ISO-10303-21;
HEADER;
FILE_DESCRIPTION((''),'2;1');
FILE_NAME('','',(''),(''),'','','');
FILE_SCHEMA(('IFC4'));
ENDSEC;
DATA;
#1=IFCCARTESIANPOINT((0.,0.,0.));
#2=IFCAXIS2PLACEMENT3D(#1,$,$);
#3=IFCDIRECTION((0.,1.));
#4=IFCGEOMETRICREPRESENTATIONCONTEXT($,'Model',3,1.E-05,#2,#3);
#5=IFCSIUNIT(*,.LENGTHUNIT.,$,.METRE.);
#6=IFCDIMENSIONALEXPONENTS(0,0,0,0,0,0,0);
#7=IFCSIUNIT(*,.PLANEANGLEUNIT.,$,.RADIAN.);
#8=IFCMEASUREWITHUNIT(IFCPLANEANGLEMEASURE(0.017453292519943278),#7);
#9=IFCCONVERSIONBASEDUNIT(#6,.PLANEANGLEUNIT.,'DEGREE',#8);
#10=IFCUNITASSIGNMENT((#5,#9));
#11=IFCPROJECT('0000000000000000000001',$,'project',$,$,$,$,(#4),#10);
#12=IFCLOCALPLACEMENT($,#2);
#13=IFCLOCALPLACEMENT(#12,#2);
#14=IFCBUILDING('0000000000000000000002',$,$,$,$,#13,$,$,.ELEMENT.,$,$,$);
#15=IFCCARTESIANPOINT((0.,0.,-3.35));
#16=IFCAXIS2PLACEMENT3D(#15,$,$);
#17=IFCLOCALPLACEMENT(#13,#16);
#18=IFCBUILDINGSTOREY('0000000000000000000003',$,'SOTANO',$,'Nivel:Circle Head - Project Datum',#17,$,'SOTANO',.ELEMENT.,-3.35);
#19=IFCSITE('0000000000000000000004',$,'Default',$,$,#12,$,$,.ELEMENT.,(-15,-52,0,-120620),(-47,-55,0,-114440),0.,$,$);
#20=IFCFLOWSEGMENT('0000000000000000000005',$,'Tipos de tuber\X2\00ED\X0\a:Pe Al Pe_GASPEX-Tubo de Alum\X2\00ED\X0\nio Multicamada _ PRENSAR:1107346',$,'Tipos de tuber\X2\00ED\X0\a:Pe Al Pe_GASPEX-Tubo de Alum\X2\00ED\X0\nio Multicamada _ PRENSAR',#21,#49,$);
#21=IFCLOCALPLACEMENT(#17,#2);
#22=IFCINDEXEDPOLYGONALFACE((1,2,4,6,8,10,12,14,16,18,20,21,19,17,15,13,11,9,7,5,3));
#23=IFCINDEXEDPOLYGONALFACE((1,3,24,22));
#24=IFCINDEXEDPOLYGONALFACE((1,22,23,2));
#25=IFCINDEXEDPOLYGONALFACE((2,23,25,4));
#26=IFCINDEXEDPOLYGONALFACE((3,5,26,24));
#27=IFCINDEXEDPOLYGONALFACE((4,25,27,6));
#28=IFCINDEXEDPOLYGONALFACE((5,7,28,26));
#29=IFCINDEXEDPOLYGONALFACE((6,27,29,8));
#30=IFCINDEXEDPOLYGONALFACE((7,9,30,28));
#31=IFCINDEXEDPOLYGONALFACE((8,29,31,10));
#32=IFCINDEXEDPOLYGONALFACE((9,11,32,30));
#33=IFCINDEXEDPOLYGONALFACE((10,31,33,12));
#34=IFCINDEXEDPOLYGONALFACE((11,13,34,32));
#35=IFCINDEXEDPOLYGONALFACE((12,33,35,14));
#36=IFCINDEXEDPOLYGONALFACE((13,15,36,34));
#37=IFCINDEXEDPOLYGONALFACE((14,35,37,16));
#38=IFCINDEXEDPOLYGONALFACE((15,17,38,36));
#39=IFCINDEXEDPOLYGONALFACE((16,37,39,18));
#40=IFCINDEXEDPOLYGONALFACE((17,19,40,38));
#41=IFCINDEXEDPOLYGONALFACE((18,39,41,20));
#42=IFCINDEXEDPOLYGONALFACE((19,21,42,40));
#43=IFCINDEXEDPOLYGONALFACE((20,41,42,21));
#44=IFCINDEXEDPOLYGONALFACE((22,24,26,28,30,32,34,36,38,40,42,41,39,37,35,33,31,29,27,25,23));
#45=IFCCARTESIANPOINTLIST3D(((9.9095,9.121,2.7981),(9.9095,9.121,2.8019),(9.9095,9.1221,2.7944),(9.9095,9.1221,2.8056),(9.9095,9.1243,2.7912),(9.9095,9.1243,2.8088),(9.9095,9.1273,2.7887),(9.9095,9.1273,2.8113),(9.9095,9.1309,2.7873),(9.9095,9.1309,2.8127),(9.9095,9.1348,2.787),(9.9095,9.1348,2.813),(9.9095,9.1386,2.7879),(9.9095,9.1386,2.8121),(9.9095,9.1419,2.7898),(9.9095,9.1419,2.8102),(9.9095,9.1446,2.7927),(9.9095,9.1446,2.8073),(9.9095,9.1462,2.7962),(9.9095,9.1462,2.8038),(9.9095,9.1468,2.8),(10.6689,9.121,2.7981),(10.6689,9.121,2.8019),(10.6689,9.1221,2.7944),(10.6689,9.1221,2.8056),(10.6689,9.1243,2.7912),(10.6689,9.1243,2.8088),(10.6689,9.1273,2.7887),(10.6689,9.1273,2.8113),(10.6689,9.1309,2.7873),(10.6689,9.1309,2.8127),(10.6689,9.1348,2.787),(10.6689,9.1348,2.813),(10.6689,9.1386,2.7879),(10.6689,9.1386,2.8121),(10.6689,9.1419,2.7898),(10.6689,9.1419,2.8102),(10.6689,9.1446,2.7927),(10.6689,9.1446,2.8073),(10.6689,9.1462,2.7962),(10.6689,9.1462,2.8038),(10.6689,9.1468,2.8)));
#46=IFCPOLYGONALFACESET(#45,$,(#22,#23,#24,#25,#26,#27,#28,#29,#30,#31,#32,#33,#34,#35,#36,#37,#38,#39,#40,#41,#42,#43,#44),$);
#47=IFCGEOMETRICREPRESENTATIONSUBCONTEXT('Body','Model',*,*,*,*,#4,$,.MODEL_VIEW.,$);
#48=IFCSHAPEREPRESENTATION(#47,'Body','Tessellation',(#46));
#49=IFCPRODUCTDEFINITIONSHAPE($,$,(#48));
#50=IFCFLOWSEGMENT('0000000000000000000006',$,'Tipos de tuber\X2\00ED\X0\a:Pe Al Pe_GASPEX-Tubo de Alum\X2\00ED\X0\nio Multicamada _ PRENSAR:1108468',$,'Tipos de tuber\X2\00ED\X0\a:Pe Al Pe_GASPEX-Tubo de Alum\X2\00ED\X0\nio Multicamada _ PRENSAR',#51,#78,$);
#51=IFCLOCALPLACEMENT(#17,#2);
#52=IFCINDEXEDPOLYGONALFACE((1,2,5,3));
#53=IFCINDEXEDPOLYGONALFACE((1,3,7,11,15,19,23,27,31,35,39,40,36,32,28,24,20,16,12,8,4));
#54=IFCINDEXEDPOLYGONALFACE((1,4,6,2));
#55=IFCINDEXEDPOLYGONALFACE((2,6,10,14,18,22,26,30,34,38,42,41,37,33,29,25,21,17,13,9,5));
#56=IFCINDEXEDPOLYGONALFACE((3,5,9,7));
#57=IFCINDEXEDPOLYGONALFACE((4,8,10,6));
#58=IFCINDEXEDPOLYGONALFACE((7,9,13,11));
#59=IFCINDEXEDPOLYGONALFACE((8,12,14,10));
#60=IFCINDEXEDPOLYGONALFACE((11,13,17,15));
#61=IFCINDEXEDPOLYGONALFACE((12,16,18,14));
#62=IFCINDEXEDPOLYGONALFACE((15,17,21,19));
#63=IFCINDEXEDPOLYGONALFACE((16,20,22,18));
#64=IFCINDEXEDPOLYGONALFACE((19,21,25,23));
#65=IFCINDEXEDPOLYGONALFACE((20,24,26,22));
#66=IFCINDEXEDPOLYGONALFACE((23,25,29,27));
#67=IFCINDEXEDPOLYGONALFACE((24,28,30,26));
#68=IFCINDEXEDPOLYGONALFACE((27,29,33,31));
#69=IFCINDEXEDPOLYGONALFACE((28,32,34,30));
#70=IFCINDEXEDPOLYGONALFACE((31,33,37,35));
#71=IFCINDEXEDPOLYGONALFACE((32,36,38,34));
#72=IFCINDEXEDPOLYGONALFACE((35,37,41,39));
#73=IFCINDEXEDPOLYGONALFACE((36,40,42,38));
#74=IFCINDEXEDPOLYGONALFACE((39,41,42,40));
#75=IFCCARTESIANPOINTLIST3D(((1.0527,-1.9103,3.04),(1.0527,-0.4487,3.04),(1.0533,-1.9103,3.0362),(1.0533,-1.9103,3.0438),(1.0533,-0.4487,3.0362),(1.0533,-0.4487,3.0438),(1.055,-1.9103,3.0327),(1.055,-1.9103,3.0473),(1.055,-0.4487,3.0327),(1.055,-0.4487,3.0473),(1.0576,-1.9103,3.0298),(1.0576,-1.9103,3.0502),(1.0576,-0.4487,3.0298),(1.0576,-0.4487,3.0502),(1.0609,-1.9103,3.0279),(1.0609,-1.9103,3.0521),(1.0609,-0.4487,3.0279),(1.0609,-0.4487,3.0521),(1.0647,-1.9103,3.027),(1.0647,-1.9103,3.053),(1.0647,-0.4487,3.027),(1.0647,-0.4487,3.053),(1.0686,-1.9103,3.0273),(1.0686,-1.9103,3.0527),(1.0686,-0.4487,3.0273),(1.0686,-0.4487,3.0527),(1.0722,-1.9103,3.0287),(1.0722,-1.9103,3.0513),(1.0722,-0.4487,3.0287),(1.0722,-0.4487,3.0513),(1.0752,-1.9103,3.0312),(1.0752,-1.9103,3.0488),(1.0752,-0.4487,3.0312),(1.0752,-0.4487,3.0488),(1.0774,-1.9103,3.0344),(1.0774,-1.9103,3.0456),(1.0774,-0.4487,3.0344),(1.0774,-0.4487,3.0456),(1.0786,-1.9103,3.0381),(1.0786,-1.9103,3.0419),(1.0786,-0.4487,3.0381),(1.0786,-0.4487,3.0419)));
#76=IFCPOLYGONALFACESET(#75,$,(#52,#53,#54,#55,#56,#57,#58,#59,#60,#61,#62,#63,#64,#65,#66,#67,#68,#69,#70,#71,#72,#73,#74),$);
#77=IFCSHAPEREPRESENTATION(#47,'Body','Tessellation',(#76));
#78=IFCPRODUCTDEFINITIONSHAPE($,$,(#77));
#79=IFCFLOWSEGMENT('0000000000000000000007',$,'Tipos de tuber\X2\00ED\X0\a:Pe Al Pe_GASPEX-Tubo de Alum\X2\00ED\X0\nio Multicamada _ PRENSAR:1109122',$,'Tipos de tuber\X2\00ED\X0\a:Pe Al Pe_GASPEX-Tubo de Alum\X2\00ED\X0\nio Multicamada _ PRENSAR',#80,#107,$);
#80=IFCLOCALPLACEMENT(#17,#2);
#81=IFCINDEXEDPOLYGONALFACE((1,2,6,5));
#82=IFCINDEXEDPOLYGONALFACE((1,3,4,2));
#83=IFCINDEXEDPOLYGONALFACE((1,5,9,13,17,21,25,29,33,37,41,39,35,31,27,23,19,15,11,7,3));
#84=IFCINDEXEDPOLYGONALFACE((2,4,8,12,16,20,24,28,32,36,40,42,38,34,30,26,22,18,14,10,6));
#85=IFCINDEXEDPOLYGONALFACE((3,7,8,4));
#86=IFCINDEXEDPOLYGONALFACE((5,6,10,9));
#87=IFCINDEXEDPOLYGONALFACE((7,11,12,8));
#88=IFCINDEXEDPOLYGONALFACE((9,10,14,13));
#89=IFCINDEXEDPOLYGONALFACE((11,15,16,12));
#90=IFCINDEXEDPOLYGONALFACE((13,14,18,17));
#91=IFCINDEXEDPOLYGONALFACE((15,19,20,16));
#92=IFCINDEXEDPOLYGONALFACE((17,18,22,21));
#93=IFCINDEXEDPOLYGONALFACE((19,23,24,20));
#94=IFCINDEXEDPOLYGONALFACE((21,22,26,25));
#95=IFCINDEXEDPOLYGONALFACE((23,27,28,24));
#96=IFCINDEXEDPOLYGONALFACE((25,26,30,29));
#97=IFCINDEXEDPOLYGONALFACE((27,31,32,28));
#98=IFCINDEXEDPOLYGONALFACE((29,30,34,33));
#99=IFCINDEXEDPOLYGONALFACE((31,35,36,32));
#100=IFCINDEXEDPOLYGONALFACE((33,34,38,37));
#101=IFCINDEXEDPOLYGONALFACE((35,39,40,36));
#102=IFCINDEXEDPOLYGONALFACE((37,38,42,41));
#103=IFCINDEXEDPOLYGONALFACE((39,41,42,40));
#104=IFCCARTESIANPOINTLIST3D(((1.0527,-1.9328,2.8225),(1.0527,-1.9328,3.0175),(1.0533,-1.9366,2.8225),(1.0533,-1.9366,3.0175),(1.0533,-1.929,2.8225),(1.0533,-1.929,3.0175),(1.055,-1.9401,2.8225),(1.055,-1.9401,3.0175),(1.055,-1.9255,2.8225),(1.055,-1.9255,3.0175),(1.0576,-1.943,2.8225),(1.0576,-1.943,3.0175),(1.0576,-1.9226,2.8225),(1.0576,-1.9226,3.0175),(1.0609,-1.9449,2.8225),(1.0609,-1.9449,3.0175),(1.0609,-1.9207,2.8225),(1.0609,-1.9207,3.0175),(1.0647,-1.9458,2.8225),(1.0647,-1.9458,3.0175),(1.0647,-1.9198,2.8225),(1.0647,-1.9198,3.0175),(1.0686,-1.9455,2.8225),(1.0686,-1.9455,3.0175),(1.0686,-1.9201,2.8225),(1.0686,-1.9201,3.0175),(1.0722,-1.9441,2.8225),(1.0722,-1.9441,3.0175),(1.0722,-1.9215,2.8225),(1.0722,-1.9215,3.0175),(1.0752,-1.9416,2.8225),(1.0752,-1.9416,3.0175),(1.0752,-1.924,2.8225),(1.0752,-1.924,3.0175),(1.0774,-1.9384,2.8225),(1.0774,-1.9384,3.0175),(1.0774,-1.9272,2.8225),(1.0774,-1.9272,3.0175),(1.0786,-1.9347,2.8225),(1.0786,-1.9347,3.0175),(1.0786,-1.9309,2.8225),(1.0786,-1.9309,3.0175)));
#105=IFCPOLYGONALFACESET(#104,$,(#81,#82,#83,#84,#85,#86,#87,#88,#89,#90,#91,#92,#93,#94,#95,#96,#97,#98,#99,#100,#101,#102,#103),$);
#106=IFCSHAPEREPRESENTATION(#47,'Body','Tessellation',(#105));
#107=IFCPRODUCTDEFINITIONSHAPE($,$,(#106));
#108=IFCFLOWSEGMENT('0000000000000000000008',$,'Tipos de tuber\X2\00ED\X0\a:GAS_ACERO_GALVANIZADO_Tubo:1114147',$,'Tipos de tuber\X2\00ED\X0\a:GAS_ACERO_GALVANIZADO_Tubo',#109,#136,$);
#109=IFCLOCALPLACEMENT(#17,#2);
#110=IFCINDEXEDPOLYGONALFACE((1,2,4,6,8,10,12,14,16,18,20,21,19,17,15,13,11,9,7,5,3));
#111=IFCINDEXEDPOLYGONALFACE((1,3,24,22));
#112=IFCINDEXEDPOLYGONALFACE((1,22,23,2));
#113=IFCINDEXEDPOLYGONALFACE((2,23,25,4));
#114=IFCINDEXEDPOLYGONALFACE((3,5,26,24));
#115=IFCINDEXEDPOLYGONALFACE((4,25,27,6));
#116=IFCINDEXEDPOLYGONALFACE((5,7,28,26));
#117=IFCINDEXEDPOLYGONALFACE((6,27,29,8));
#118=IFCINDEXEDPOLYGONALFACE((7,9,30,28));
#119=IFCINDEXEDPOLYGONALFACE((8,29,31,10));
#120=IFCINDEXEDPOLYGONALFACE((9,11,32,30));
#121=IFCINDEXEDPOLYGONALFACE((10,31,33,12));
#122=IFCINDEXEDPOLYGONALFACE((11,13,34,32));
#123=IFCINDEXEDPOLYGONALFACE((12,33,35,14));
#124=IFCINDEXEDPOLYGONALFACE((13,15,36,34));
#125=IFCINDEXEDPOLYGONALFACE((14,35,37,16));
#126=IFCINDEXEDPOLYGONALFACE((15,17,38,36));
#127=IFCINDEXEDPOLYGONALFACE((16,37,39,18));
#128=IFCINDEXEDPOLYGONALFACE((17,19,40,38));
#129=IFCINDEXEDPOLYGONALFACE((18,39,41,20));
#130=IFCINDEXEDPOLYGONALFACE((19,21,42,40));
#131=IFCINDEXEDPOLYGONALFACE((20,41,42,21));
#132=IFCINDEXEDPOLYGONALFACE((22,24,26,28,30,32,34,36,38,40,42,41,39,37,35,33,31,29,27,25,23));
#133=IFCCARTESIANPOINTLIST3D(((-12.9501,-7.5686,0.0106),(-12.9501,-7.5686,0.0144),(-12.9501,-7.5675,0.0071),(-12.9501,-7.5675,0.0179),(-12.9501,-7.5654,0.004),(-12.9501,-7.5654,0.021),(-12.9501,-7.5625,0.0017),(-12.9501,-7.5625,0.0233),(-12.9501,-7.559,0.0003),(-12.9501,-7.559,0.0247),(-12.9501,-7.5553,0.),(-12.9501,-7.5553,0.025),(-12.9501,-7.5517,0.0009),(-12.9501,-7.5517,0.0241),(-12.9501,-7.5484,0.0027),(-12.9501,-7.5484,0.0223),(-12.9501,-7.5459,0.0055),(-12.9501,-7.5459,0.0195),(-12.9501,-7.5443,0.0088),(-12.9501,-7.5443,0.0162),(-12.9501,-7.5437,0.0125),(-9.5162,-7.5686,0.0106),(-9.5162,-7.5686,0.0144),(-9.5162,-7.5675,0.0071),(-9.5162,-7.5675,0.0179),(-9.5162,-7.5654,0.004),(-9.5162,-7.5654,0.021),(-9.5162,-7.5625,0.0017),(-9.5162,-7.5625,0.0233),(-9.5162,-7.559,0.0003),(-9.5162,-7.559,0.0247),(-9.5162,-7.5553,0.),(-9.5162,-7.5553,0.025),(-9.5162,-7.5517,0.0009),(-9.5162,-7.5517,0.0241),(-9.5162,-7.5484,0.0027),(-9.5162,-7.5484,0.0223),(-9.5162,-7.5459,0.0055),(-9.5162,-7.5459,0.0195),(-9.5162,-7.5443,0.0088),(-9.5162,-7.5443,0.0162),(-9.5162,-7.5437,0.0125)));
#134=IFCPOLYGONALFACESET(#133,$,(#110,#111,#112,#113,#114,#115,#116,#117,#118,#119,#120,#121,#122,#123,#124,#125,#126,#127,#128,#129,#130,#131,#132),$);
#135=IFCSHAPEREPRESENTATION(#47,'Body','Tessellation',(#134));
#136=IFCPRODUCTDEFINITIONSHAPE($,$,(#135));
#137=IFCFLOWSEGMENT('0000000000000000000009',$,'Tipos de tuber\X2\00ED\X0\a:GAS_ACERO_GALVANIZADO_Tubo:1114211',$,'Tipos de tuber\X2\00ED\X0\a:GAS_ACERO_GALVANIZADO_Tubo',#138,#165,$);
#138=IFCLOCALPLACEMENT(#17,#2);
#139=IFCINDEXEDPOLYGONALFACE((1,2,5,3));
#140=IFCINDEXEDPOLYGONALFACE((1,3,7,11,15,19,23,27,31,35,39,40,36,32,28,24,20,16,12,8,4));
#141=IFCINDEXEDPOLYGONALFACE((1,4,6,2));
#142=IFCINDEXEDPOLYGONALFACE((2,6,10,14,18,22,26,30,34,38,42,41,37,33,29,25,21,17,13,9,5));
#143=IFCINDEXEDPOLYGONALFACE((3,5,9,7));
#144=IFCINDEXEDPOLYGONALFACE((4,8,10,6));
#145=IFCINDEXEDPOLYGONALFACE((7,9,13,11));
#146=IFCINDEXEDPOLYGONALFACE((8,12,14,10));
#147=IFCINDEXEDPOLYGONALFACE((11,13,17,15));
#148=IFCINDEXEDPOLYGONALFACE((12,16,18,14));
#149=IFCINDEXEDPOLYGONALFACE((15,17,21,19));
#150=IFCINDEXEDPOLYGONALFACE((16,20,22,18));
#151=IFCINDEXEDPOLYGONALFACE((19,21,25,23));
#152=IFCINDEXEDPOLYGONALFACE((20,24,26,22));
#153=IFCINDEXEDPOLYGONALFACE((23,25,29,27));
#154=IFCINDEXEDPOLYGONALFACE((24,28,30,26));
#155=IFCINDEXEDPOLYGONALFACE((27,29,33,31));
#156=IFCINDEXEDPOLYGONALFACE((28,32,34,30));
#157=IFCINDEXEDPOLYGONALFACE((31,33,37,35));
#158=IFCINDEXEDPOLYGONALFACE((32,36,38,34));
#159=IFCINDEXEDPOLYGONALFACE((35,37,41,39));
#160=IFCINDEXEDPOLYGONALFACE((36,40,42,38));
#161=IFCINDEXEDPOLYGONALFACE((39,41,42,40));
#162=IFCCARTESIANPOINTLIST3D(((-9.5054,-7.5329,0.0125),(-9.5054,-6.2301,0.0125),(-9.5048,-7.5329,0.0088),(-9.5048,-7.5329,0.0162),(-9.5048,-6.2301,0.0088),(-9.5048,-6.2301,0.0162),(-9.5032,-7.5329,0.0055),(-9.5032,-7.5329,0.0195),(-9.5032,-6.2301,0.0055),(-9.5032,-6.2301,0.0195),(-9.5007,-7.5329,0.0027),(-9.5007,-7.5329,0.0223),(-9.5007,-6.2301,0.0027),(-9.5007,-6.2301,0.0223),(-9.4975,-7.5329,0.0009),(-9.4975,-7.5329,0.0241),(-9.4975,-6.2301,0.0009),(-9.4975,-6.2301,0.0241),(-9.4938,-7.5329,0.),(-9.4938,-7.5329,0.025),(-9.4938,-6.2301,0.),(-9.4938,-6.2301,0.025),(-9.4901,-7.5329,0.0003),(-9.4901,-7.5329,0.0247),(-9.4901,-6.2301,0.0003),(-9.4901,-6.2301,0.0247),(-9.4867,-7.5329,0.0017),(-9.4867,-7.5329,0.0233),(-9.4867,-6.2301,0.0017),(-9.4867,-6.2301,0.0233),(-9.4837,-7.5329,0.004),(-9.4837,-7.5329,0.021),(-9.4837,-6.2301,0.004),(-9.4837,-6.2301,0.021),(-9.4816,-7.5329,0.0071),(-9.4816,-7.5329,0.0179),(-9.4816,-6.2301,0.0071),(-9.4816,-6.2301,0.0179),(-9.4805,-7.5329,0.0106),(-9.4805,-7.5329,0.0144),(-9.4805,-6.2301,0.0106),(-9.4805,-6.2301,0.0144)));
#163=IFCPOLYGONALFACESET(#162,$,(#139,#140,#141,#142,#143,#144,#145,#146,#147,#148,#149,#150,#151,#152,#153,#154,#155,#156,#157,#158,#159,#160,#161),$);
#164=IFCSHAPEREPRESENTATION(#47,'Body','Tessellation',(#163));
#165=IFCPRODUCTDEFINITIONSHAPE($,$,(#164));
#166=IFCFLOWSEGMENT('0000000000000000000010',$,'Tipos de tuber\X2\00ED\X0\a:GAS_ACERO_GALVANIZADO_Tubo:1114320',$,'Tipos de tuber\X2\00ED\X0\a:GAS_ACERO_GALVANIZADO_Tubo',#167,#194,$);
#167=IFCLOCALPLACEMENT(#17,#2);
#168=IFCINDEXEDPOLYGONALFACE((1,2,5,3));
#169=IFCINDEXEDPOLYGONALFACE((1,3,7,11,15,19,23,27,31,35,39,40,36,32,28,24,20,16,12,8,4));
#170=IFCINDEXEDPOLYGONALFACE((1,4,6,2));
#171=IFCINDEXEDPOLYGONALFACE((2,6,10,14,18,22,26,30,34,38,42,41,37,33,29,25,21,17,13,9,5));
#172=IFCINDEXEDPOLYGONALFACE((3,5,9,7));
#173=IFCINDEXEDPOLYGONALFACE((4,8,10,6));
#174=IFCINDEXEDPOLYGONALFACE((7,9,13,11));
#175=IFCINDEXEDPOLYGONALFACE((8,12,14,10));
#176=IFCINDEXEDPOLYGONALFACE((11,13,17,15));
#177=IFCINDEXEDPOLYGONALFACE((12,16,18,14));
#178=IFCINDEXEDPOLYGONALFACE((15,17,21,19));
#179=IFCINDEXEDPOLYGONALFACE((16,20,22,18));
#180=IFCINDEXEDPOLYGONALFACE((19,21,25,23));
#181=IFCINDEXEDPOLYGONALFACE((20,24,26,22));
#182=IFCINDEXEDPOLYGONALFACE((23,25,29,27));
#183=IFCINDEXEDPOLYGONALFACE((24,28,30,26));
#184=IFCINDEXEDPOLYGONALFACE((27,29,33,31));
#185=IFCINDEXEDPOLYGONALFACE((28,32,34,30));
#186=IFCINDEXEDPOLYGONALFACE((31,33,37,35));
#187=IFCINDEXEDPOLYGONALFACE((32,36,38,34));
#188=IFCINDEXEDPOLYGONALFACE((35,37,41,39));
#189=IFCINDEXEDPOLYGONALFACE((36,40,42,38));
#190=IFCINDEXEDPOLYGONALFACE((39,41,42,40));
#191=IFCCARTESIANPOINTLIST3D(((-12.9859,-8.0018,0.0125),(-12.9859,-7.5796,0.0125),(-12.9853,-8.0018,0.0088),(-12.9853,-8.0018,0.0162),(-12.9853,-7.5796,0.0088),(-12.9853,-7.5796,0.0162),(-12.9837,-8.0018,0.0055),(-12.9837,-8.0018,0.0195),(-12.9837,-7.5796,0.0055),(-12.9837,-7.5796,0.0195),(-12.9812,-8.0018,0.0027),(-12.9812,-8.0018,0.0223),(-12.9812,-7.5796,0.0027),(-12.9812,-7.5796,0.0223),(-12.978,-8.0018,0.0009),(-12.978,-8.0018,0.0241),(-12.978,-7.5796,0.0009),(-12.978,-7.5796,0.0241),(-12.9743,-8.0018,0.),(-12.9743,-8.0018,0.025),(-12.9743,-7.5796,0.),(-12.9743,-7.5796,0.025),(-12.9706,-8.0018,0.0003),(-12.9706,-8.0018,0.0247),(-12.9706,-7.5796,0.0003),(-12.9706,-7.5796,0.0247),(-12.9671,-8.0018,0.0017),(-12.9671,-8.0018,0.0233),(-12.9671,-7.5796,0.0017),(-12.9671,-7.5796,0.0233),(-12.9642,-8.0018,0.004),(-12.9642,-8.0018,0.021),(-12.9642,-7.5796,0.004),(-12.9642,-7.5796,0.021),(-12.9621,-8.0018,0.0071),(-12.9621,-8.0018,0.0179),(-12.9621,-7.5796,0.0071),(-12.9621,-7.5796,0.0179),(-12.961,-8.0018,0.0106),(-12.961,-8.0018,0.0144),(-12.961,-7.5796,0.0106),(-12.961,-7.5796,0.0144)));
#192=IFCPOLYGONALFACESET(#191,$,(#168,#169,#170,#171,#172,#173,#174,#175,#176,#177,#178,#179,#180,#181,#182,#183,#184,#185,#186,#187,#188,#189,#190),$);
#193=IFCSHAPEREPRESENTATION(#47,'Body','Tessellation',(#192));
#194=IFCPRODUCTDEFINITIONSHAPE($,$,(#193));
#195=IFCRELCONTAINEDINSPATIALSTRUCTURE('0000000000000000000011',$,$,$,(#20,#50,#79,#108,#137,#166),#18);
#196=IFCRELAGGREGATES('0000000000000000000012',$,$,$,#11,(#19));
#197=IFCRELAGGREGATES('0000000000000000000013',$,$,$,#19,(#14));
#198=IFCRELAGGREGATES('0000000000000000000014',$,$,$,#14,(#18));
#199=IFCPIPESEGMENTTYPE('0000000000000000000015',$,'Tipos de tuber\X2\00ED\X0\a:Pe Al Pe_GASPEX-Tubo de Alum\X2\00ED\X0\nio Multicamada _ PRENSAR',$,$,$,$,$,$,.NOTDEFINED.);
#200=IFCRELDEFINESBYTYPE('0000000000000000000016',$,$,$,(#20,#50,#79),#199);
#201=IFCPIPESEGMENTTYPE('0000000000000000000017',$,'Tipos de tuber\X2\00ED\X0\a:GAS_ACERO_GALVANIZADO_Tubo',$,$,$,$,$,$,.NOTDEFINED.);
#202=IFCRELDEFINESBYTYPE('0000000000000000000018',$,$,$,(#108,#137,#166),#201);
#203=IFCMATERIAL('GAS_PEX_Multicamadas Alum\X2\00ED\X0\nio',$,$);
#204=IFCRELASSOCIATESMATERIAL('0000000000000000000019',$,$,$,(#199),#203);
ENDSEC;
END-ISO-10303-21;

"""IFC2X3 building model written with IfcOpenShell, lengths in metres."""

from ifc_helpers import new_model, entity, si_unit, converted_unit, direction, frame, frame_2d, origin, origin_2d_with_axis, place, context, subcontext, project, spatial, circle, extrude, material, type_object, element, save


model = new_model("IFC2X3")

# Units and contexts
model_context = context("Model", 3, precision=1e-05, world=origin(), true_north=direction((0.0, 1.0)))
body_context = subcontext(model_context, "Body", "Model", "MODEL_VIEW")
ifc_project = project(units=[si_unit("LENGTHUNIT", "METRE"), converted_unit("PLANEANGLEUNIT", "DEGREE", entity("IfcPlaneAngleMeasure", 0.017453292519943278), si_unit("PLANEANGLEUNIT", "RADIAN"), dimensions=[0, 0, 0, 0, 0, 0, 0])], contexts=[model_context])

# Site, building, storey
site_placement = place(None, origin())
site = spatial("IfcSite", under=ifc_project, at=site_placement, Name="Default", CompositionType="ELEMENT", RefLatitude=(-15, -52, 0, -120620), RefLongitude=(-47, -55, 0, -114440), RefElevation=0.0)
building_placement = place(site_placement, origin())
building = spatial("IfcBuilding", under=site, at=building_placement, CompositionType="ELEMENT")
storey_placement = place(building_placement, frame((0.0, 0.0, -3.35)))
storey = spatial("IfcBuildingStorey", under=building, at=storey_placement, Name="SOTANO", ObjectType="Nivel:Circle Head - Project Datum", LongName="SOTANO", CompositionType="ELEMENT", Elevation=-3.35)

# Flow segments
ifc_material = material(Name="GAS_PEX_Multicamadas Alumínio")
pipe_segment_type_1 = type_object("IfcPipeSegmentType", Name="Tipos de tubería:Pe Al Pe_GASPEX-Tubo de Alumínio Multicamada _ PRENSAR", PredefinedType="NOTDEFINED", material=ifc_material)
flow_segment_1_placement = place(storey_placement, origin())
element("IfcFlowSegment", 1, at=flow_segment_1_placement, inside=storey, type_object=pipe_segment_type_1, Name="Tipos de tubería:Pe Al Pe_GASPEX-Tubo de Alumínio Multicamada _ PRENSAR:1107346", ObjectType="Tipos de tubería:Pe Al Pe_GASPEX-Tubo de Alumínio Multicamada _ PRENSAR", context=body_context, shape_type="SweptSolid", body=[
    extrude(circle(Radius=0.013, at=origin_2d_with_axis()), frame((9.9095, 9.1338, 2.8), z_axis=(1.0, 0.0, 0.0), x_axis=(0.0, 1.0, 0.0)), (0.0, 0.0, 1.0), 0.7594),
])
flow_segment_2_placement = place(storey_placement, origin())
element("IfcFlowSegment", 2, at=flow_segment_2_placement, inside=storey, type_object=pipe_segment_type_1, Name="Tipos de tubería:Pe Al Pe_GASPEX-Tubo de Alumínio Multicamada _ PRENSAR:1108468", ObjectType="Tipos de tubería:Pe Al Pe_GASPEX-Tubo de Alumínio Multicamada _ PRENSAR", context=body_context, shape_type="SweptSolid", body=[
    extrude(circle(Radius=0.013, at=frame_2d((0.0, 0.0), x_axis=(1.0, 0.0))), frame((1.0657, -1.9103, 3.04), z_axis=(0.0, 1.0, 0.0), x_axis=(-1.0, 0.0, 0.0)), (0.0, 0.0, 1.0), 1.4616),
])
flow_segment_3_placement = place(storey_placement, origin())
element("IfcFlowSegment", 3, at=flow_segment_3_placement, inside=storey, type_object=pipe_segment_type_1, Name="Tipos de tubería:Pe Al Pe_GASPEX-Tubo de Alumínio Multicamada _ PRENSAR:1109122", ObjectType="Tipos de tubería:Pe Al Pe_GASPEX-Tubo de Alumínio Multicamada _ PRENSAR", context=body_context, shape_type="SweptSolid", body=[
    extrude(circle(Radius=0.013, at=origin_2d_with_axis()), frame((1.0657, -1.9328, 2.8225), z_axis=(0.0, 0.0, 1.0), x_axis=(-1.0, 0.0, 0.0)), (0.0, 0.0, 1.0), 0.195),
])
pipe_segment_type_2 = type_object("IfcPipeSegmentType", Name="Tipos de tubería:GAS_ACERO_GALVANIZADO_Tubo", PredefinedType="NOTDEFINED")
flow_segment_4_placement = place(storey_placement, origin())
element("IfcFlowSegment", 4, at=flow_segment_4_placement, inside=storey, type_object=pipe_segment_type_2, Name="Tipos de tubería:GAS_ACERO_GALVANIZADO_Tubo:1114147", ObjectType="Tipos de tubería:GAS_ACERO_GALVANIZADO_Tubo", context=body_context, shape_type="SweptSolid", body=[
    extrude(circle(Radius=0.0125, at=frame_2d((0.0, 0.0), x_axis=(1.0, 0.0))), frame((-12.9501, -7.5562, 0.0125), z_axis=(1.0, 0.0, 0.0), x_axis=(0.0, 1.0, 0.0)), (0.0, 0.0, 1.0), 3.4338),
])
flow_segment_5_placement = place(storey_placement, origin())
element("IfcFlowSegment", 5, at=flow_segment_5_placement, inside=storey, type_object=pipe_segment_type_2, Name="Tipos de tubería:GAS_ACERO_GALVANIZADO_Tubo:1114211", ObjectType="Tipos de tubería:GAS_ACERO_GALVANIZADO_Tubo", context=body_context, shape_type="SweptSolid", body=[
    extrude(circle(Radius=0.0125, at=frame_2d((0.0, 0.0), x_axis=(1.0, 0.0))), frame((-9.4929, -7.5329, 0.0125), z_axis=(0.0, 1.0, 0.0), x_axis=(-1.0, 0.0, 0.0)), (0.0, 0.0, 1.0), 1.3028),
])
flow_segment_6_placement = place(storey_placement, origin())
element("IfcFlowSegment", 6, at=flow_segment_6_placement, inside=storey, type_object=pipe_segment_type_2, Name="Tipos de tubería:GAS_ACERO_GALVANIZADO_Tubo:1114320", ObjectType="Tipos de tubería:GAS_ACERO_GALVANIZADO_Tubo", context=body_context, shape_type="SweptSolid", body=[
    extrude(circle(Radius=0.0125, at=origin_2d_with_axis()), frame((-12.9734, -8.0018, 0.0125), z_axis=(0.0, 1.0, 0.0), x_axis=(-1.0, 0.0, 0.0)), (0.0, 0.0, 1.0), 0.4222),
])

save(model, "model.ifc")
